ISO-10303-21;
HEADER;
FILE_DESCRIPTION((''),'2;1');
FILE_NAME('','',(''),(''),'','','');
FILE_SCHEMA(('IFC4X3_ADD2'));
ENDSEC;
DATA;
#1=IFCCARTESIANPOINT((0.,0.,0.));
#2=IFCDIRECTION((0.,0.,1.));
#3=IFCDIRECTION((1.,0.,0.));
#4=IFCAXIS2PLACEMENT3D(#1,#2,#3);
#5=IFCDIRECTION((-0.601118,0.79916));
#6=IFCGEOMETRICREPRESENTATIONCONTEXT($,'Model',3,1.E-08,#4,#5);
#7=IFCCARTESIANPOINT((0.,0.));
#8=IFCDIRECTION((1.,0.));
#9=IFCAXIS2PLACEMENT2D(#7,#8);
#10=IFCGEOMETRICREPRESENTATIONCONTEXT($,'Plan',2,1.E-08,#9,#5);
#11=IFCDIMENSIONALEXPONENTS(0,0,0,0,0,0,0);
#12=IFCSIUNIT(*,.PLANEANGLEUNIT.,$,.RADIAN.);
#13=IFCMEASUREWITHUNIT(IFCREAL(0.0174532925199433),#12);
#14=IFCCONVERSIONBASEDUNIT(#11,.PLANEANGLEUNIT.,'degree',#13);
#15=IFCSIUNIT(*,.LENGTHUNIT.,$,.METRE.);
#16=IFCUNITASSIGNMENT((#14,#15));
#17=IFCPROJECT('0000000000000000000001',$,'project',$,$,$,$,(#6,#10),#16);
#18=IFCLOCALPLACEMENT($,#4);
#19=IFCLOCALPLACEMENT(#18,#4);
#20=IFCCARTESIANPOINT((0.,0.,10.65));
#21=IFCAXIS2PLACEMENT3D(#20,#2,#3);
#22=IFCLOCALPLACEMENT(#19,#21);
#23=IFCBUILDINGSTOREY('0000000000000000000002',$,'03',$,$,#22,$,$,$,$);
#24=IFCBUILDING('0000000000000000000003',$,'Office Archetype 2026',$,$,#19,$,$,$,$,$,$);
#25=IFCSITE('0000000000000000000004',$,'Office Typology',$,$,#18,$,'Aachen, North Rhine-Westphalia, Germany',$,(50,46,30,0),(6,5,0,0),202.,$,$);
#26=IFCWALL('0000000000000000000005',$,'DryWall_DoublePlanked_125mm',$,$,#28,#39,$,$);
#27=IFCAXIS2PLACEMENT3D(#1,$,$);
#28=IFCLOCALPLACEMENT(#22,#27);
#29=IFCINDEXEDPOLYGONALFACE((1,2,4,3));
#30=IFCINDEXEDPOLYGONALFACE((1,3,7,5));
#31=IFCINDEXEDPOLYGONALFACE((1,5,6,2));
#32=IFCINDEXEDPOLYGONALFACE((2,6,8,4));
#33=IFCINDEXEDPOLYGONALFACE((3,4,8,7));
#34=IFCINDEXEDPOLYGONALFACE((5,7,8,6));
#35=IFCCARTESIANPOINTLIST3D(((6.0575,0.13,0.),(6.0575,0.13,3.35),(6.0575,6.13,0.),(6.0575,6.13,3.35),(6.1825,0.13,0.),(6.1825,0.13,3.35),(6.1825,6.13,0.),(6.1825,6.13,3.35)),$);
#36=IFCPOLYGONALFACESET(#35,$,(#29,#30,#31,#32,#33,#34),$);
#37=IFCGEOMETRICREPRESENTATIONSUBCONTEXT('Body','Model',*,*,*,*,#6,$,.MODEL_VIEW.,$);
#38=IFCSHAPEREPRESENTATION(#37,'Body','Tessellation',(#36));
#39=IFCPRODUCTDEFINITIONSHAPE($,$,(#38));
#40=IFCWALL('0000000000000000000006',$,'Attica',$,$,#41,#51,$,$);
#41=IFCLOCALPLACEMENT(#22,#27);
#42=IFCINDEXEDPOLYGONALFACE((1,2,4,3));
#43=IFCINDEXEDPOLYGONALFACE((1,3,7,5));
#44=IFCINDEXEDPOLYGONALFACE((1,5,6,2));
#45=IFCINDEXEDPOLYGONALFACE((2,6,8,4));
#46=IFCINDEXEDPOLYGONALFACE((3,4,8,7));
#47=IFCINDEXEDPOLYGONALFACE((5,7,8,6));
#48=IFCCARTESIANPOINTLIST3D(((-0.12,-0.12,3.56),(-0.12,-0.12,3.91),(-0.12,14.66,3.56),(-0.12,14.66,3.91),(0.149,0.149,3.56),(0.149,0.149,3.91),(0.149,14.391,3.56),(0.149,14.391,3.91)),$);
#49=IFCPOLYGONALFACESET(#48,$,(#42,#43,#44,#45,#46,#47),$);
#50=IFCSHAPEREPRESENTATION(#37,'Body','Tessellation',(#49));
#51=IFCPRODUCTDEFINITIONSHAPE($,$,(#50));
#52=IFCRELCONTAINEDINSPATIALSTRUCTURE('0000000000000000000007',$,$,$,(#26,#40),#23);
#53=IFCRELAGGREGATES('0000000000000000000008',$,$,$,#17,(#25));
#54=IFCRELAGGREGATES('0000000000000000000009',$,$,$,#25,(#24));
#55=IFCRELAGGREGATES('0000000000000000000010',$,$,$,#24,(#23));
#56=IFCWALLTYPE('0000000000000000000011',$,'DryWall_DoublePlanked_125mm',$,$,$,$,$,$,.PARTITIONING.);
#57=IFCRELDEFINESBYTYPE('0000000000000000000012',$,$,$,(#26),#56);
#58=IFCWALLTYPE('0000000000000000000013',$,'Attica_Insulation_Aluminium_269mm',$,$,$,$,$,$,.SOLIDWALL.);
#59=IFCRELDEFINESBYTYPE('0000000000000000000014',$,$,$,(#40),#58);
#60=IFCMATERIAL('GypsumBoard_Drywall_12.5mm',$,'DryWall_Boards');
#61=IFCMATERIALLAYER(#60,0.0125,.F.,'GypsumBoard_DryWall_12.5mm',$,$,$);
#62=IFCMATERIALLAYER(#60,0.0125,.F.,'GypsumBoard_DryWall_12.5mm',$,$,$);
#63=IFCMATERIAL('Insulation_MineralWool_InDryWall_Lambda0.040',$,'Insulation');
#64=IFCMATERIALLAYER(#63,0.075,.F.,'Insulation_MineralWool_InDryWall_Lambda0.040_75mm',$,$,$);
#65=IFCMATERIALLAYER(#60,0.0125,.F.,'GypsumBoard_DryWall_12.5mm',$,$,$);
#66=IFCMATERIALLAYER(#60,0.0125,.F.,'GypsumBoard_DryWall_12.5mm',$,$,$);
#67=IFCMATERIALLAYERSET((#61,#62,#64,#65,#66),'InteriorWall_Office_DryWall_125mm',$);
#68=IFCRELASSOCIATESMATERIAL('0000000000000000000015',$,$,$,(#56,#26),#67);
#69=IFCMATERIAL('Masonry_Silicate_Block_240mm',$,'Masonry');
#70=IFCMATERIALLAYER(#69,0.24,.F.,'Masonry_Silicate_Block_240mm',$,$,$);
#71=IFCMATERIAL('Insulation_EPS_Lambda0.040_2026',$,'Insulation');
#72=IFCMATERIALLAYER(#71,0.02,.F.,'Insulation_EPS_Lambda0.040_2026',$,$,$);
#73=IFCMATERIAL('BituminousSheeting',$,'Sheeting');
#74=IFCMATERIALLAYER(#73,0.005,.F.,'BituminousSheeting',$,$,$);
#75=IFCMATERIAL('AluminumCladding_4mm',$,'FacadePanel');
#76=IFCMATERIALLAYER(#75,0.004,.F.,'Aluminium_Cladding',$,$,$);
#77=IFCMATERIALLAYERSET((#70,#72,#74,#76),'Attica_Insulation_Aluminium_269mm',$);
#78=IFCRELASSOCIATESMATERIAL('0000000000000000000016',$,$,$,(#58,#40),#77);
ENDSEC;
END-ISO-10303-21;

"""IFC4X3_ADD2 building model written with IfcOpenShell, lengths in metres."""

from ifc_helpers import new_model, entity, si_unit, converted_unit, direction, frame, origin_with_axes, origin_2d_with_axis, place, context, subcontext, project, spatial, line, indexed_curve, outline, extrude, material, layer, layer_set, layer_usage, type_object, element, save


model = new_model("IFC4X3_ADD2")

# Units and contexts
model_context = context("Model", 3, precision=1e-08, world=origin_with_axes(), true_north=direction((-0.601118, 0.79916)))
plan_context = context("Plan", 2, precision=1e-08, world=origin_2d_with_axis(), true_north=direction((-0.601118, 0.79916)))
body_context = subcontext(model_context, "Body", "Model", "MODEL_VIEW")
ifc_project = project(units=[converted_unit("PLANEANGLEUNIT", "degree", entity("IfcReal", 0.0174532925199433), si_unit("PLANEANGLEUNIT", "RADIAN"), dimensions=[0, 0, 0, 0, 0, 0, 0]), si_unit("LENGTHUNIT", "METRE")], contexts=[model_context, plan_context])

# Site, building, storey
site_placement = place(None, origin_with_axes())
site = spatial("IfcSite", under=ifc_project, at=site_placement, Name="Office Typology", LongName="Aachen, North Rhine-Westphalia, Germany", RefLatitude=(50, 46, 30, 0), RefLongitude=(6, 5, 0, 0), RefElevation=202.0)
building_placement = place(site_placement, origin_with_axes())
building = spatial("IfcBuilding", under=site, at=building_placement, Name="Office Archetype 2026")
storey_placement = place(building_placement, frame((0.0, 0.0, 10.65), z_axis=(0.0, 0.0, 1.0), x_axis=(1.0, 0.0, 0.0)))
storey = spatial("IfcBuildingStorey", under=building, at=storey_placement, Name="03")

# Shared definitions
ifc_material_1 = material(Name="Masonry_Silicate_Block_240mm", Category="Masonry")

# Wall
ifc_material_2 = material(Name="GypsumBoard_Drywall_12.5mm", Category="DryWall_Boards")
ifc_layer_1 = layer(ifc_material_2, 0.0125, ventilated=False, Name="GypsumBoard_DryWall_12.5mm")
ifc_layer_2 = layer(ifc_material_2, 0.0125, ventilated=False, Name="GypsumBoard_DryWall_12.5mm")
ifc_material_3 = material(Name="Insulation_MineralWool_InDryWall_Lambda0.040", Category="Insulation")
ifc_layer_3 = layer(ifc_material_3, 0.075, ventilated=False, Name="Insulation_MineralWool_InDryWall_Lambda0.040_75mm")
ifc_layer_4 = layer(ifc_material_2, 0.0125, ventilated=False, Name="GypsumBoard_DryWall_12.5mm")
ifc_layer_5 = layer(ifc_material_2, 0.0125, ventilated=False, Name="GypsumBoard_DryWall_12.5mm")
ifc_layer_set_1 = layer_set([ifc_layer_1, ifc_layer_2, ifc_layer_3, ifc_layer_4, ifc_layer_5], Name="InteriorWall_Office_DryWall_125mm")
ifc_layer_usage_1 = layer_usage(ifc_layer_set_1, "AXIS2", "POSITIVE", 0.0)
wall_type_1 = type_object("IfcWallType", Name="DryWall_DoublePlanked_125mm", PredefinedType="PARTITIONING", material=ifc_layer_set_1)
wall_1_placement = place(storey_placement, frame((6.0575, 6.13, 0.0), z_axis=(0.0, 0.0, 1.0), x_axis=(0.0, -1.0, 0.0)))
element("IfcWall", 1, at=wall_1_placement, inside=storey, type_object=wall_type_1, material=ifc_layer_usage_1, Name="DryWall_DoublePlanked_125mm", context=body_context, shape_type="SweptSolid", body=[
    extrude(outline(indexed_curve([(0.0, 0.0), (0.0, 0.125), (6.0, 0.125), (6.0, 0.0)], segments=[line(1, 2, 3, 4, 1)])), origin_with_axes(), (0.0, 0.0, 1.0), 3.35),
])

# Wall
ifc_layer_6 = layer(ifc_material_1, 0.24, ventilated=False, Name="Masonry_Silicate_Block_240mm")
ifc_material_4 = material(Name="Insulation_EPS_Lambda0.040_2026", Category="Insulation")
ifc_layer_7 = layer(ifc_material_4, 0.02, ventilated=False, Name="Insulation_EPS_Lambda0.040_2026")
ifc_material_5 = material(Name="BituminousSheeting", Category="Sheeting")
ifc_layer_8 = layer(ifc_material_5, 0.005, ventilated=False, Name="BituminousSheeting")
ifc_material_6 = material(Name="AluminumCladding_4mm", Category="FacadePanel")
ifc_layer_9 = layer(ifc_material_6, 0.004, ventilated=False, Name="Aluminium_Cladding")
ifc_layer_set_2 = layer_set([ifc_layer_6, ifc_layer_7, ifc_layer_8, ifc_layer_9], Name="Attica_Insulation_Aluminium_269mm")
ifc_layer_usage_2 = layer_usage(ifc_layer_set_2, "AXIS2", "POSITIVE", 0.0)
wall_type_2 = type_object("IfcWallType", Name="Attica_Insulation_Aluminium_269mm", PredefinedType="SOLIDWALL", material=ifc_layer_set_2)
wall_2_placement = place(storey_placement, frame((-0.12, 14.66, 3.56), z_axis=(0.0, 0.0, 1.0), x_axis=(0.0, -1.0, 0.0)))
element("IfcWall", 2, at=wall_2_placement, inside=storey, type_object=wall_type_2, material=ifc_layer_usage_2, Name="Attica", context=body_context, shape_type="SweptSolid", body=[
    extrude(outline(indexed_curve([(0.0, 0.0), (0.269, 0.269), (14.511, 0.269), (14.78, 0.0)], segments=[line(1, 2, 3, 4, 1)])), origin_with_axes(), (0.0, 0.0, 1.0), 0.35),
])

save(model, "model.ifc")
